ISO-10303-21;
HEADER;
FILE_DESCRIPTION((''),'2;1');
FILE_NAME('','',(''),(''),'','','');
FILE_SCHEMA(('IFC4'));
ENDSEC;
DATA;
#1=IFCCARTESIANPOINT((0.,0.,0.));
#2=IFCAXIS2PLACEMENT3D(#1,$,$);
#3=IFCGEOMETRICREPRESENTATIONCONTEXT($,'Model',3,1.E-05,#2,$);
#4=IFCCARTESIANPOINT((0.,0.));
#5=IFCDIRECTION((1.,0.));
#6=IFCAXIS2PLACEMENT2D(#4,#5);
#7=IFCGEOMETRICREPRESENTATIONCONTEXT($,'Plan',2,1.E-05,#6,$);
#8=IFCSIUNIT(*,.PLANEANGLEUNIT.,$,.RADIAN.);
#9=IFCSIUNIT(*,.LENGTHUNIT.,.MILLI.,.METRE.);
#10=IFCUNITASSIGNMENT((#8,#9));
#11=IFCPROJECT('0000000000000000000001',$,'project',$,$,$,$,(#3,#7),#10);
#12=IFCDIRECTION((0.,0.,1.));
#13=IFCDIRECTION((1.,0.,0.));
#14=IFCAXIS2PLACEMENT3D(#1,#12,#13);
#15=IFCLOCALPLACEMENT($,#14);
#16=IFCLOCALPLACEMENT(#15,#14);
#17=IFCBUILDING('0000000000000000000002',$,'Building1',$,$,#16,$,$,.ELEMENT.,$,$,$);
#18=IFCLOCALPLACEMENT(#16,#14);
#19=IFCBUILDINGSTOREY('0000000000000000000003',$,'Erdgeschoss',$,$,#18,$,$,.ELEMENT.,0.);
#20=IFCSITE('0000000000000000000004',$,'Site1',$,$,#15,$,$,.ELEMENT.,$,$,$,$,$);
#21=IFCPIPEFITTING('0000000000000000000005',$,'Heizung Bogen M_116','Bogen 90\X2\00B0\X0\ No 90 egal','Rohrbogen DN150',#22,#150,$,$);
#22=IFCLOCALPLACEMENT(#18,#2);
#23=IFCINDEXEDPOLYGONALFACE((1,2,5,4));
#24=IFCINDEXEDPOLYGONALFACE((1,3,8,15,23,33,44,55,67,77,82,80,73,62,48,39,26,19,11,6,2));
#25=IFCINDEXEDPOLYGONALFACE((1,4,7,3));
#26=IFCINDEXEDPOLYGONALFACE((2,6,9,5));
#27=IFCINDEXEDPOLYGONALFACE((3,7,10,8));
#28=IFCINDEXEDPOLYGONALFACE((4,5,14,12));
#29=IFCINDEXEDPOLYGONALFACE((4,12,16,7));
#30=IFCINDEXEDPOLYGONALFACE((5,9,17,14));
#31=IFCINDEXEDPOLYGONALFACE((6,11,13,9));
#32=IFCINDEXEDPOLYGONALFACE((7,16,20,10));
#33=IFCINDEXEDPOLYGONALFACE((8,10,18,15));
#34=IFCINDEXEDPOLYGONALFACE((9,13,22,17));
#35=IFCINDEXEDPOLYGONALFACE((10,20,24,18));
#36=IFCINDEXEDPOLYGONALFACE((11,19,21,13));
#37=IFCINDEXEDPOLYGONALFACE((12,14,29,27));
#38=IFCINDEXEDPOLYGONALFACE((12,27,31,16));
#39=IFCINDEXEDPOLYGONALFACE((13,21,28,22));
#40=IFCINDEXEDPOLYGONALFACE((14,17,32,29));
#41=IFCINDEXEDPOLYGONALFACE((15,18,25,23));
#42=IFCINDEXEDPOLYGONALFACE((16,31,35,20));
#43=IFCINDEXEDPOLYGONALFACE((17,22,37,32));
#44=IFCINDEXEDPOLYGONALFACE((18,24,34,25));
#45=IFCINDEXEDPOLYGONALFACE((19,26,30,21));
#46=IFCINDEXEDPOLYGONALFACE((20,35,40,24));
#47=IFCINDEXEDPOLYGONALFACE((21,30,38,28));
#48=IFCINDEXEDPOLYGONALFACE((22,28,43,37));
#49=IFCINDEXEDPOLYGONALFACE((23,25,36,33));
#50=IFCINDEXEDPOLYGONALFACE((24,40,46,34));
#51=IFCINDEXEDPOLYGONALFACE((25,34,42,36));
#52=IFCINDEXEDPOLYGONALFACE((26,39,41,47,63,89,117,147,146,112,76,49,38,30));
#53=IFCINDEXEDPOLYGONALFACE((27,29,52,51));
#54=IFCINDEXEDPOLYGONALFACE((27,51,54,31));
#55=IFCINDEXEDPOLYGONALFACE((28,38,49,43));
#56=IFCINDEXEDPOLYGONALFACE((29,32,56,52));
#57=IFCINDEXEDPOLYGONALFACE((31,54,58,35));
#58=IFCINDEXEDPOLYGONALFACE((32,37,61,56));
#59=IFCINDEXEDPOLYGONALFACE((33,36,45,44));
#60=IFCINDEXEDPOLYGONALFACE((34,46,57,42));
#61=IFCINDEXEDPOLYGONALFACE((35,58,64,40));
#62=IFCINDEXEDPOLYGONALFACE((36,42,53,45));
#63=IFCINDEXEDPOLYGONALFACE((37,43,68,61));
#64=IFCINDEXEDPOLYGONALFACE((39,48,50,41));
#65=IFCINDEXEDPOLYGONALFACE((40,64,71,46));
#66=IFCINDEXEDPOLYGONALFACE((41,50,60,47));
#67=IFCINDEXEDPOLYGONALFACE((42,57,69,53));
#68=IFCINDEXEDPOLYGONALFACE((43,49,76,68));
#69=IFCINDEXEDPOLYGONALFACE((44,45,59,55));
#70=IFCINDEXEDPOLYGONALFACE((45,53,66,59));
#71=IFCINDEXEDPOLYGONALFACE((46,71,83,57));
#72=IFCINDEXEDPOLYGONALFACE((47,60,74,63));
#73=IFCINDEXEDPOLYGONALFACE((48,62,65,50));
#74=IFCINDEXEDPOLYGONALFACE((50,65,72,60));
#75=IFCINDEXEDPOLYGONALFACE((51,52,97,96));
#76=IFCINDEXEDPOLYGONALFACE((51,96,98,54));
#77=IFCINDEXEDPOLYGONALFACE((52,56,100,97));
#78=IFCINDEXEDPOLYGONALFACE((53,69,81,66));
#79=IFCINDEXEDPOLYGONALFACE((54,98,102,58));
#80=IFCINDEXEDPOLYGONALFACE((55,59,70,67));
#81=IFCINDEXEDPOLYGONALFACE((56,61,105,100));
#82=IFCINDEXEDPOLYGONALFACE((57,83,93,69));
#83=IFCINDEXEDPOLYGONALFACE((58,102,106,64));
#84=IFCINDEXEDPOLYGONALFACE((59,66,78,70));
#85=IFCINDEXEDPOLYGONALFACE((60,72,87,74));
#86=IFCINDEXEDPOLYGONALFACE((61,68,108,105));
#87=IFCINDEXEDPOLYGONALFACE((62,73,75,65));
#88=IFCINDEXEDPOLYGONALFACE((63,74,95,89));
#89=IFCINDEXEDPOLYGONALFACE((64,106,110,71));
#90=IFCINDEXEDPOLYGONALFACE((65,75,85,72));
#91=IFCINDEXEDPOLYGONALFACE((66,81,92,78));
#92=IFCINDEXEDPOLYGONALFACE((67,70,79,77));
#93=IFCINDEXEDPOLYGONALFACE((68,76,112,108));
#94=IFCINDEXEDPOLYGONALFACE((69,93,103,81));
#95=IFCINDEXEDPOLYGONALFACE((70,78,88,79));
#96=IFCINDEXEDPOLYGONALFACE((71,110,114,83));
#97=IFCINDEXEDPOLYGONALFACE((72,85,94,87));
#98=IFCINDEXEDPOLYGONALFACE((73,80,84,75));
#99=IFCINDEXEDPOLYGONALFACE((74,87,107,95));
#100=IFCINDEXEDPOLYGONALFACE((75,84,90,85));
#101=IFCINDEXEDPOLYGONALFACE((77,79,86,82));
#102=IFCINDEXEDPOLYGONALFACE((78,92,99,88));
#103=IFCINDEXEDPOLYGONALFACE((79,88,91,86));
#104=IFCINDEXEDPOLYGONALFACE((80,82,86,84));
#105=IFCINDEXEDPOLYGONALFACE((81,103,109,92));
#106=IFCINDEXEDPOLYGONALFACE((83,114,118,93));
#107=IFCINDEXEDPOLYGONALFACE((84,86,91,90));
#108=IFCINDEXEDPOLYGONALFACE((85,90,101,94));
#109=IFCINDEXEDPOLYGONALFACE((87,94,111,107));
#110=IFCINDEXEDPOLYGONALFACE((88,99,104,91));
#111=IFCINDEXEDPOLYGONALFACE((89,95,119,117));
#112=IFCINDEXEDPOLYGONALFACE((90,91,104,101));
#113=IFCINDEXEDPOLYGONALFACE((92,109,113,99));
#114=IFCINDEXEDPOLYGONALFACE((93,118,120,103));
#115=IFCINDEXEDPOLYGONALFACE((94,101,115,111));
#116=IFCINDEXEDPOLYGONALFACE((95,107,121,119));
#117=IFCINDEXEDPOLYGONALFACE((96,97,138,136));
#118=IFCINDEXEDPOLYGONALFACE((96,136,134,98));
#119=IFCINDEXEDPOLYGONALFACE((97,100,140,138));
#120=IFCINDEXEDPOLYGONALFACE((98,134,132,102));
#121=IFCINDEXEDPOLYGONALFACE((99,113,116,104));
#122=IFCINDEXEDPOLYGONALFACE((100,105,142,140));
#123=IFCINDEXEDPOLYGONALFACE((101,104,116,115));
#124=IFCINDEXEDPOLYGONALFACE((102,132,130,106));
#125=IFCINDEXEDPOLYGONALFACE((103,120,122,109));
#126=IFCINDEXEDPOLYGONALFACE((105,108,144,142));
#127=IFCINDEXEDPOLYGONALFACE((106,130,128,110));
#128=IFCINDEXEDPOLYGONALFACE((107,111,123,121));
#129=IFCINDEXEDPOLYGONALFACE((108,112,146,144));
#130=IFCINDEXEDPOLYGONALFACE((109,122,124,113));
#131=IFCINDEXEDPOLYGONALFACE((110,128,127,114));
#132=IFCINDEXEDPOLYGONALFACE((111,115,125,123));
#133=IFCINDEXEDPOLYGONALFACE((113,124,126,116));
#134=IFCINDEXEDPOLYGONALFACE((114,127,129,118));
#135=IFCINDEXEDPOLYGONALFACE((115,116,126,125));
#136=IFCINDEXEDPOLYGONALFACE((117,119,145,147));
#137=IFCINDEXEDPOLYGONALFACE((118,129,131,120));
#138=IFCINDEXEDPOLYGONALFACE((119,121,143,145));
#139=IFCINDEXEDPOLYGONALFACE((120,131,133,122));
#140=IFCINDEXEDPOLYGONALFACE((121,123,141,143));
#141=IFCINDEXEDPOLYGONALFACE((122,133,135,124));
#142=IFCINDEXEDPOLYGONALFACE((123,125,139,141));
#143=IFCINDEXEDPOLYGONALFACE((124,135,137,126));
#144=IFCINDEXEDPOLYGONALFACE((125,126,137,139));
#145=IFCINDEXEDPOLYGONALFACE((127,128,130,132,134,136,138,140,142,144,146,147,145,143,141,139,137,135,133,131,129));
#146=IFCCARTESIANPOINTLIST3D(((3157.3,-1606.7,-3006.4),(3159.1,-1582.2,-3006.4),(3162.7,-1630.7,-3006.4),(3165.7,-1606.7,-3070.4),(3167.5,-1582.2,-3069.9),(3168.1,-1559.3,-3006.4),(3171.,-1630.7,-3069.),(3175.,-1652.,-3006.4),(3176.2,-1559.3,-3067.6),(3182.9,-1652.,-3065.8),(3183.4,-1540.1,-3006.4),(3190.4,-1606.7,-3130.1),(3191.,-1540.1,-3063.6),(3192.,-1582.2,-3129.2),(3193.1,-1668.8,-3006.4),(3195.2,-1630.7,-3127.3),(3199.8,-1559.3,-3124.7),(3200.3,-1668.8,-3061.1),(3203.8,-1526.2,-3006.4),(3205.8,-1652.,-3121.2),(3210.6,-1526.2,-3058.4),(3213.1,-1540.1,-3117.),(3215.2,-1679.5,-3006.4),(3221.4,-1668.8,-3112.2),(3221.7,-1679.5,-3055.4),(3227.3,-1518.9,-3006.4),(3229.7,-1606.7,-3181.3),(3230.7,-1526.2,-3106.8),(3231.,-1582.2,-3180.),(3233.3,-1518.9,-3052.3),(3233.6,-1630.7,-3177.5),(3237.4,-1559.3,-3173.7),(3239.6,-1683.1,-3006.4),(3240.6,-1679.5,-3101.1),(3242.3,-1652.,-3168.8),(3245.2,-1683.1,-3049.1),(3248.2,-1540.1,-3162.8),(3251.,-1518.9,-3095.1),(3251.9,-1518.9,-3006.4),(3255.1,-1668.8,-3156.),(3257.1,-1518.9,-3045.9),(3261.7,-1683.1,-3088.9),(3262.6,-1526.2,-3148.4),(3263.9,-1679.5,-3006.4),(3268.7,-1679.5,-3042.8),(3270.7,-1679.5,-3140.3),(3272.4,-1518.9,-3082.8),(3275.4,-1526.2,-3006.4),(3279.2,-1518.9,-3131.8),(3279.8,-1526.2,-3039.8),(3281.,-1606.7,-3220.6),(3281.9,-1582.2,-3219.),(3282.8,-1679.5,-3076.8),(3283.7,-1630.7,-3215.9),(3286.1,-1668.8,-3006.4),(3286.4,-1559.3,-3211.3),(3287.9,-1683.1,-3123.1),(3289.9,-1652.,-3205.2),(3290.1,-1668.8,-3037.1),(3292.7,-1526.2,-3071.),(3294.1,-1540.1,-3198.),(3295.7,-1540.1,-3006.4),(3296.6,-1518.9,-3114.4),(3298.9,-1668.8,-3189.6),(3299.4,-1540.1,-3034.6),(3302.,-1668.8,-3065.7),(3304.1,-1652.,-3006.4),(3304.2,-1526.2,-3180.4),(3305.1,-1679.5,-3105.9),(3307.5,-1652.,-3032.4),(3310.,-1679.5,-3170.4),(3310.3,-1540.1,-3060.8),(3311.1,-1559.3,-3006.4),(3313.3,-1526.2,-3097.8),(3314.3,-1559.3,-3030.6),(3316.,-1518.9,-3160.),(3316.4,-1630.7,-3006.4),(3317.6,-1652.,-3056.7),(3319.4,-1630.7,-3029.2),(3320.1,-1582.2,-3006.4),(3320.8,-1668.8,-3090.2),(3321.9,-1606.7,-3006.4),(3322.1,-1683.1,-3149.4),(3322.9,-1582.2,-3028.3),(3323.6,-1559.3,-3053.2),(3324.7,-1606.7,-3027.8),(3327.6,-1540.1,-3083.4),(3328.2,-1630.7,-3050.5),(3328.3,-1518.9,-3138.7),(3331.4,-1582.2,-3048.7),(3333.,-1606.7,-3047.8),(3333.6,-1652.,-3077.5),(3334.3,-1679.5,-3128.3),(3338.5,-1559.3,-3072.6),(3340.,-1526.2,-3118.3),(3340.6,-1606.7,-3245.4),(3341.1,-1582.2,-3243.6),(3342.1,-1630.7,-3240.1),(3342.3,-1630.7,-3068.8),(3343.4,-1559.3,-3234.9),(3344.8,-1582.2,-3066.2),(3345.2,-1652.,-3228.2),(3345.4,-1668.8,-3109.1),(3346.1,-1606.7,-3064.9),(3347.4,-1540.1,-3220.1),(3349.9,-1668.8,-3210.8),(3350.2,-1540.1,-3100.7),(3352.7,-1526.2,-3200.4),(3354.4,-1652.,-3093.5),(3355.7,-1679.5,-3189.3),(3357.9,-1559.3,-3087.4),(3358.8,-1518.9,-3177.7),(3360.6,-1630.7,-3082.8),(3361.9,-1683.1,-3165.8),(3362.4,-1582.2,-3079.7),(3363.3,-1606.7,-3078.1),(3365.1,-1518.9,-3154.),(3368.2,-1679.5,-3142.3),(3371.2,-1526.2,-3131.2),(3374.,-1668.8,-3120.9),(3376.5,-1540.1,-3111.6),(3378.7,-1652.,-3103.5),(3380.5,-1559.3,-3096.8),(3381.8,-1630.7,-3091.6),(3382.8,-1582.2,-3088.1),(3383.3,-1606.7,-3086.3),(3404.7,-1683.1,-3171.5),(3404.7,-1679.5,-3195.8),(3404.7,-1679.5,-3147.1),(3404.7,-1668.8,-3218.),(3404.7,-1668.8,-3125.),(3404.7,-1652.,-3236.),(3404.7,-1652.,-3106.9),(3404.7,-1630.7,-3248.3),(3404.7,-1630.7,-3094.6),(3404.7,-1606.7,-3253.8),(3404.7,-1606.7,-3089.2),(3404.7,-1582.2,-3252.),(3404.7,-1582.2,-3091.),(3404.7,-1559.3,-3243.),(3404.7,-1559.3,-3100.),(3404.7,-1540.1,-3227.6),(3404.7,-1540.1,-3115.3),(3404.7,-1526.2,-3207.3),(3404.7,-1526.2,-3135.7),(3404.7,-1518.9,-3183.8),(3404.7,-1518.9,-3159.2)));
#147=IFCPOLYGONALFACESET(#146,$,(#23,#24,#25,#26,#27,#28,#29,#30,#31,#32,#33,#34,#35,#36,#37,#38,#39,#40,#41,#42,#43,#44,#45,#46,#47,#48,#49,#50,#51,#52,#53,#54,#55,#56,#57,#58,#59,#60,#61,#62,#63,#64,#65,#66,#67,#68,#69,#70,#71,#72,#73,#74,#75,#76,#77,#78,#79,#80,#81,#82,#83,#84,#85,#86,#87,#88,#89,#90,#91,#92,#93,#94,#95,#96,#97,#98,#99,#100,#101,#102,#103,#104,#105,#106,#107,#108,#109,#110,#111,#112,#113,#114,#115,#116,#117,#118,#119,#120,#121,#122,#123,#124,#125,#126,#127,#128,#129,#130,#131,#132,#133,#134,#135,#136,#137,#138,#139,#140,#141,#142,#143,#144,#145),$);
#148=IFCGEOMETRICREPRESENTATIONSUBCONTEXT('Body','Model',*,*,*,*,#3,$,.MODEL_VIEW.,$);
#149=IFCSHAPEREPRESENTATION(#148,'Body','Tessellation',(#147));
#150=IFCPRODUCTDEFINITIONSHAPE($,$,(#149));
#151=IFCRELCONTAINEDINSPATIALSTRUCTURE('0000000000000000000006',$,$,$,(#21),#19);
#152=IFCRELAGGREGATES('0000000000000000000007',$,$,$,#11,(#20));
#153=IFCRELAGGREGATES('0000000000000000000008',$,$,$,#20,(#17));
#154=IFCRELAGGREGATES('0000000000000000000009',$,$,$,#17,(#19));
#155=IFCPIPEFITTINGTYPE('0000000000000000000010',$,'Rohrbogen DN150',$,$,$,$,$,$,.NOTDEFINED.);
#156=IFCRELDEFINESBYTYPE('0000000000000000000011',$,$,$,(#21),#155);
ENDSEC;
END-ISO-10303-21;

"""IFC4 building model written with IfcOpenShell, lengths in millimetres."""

from ifc_helpers import new_model, entity, si_unit, frame, origin, origin_with_axes, origin_2d_with_axis, place, context, subcontext, project, spatial, source, transform, mapped, type_object, element, save


model = new_model("IFC4")

# Units and contexts
model_context = context("Model", 3, precision=1e-05, world=origin())
plan_context = context("Plan", 2, precision=1e-05, world=origin_2d_with_axis())
body_context = subcontext(model_context, "Body", "Model", "MODEL_VIEW")
ifc_project = project(units=[si_unit("PLANEANGLEUNIT", "RADIAN"), si_unit("LENGTHUNIT", "METRE", prefix="MILLI")], contexts=[model_context, plan_context])

# Site, building, storey
site_placement = place(None, origin_with_axes())
site = spatial("IfcSite", under=ifc_project, at=site_placement, Name="Site1", CompositionType="ELEMENT")
building_placement = place(site_placement, origin_with_axes())
building = spatial("IfcBuilding", under=site, at=building_placement, Name="Building1", CompositionType="ELEMENT")
storey_placement = place(building_placement, origin_with_axes())
storey = spatial("IfcBuildingStorey", under=building, at=storey_placement, Name="Erdgeschoss", CompositionType="ELEMENT", Elevation=0.0)

# Pipe fitting
pipe_fitting_type_1 = type_object("IfcPipeFittingType", Name="Rohrbogen DN150", PredefinedType="NOTDEFINED")
ifc_direction_1 = entity("IfcDirection", [-1.0, 0.0, 0.0])
shared_shape_1 = source(origin_with_axes(), body_context, "Body", "SolidModel", [
    entity("IfcRevolvedAreaSolid", entity("IfcCircleProfileDef", "AREA", None, entity("IfcAxis2Placement2D", entity("IfcCartesianPoint", [0.0, 0.0]), entity("IfcDirection", [1.0, 0.0])), 82.5), entity("IfcAxis2Placement3D", entity("IfcCartesianPoint", [123.8, 41.3, 0.0]), ifc_direction_1, entity("IfcDirection", [0.0, 0.0, -1.0])), entity("IfcAxis1Placement", entity("IfcCartesianPoint", [0.0, 165.1, 0.0]), ifc_direction_1), 1.570796),
])
pipe_fitting_1_placement = place(storey_placement, frame((3280.9, -1600.6, -3130.2), z_axis=(0.0, 0.0, 1.0), x_axis=(1.0, 0.0, 0.0)))
element("IfcPipeFitting", 1, at=pipe_fitting_1_placement, inside=storey, type_object=pipe_fitting_type_1, Name="Heizung Bogen M_116", Description="Bogen 90° No 90 egal", ObjectType="Rohrbogen DN150", context=body_context, shape_type="MappedRepresentation", body=[
    mapped(shared_shape_1, transform((0.0, 0.0, 0.0), x_axis=(1.0, 0.0, 0.0), y_axis=(0.0, 0.0, -1.0), z_axis=(0.0, 1.0, 0.0), scale=1.0)),
])

save(model, "model.ifc")
